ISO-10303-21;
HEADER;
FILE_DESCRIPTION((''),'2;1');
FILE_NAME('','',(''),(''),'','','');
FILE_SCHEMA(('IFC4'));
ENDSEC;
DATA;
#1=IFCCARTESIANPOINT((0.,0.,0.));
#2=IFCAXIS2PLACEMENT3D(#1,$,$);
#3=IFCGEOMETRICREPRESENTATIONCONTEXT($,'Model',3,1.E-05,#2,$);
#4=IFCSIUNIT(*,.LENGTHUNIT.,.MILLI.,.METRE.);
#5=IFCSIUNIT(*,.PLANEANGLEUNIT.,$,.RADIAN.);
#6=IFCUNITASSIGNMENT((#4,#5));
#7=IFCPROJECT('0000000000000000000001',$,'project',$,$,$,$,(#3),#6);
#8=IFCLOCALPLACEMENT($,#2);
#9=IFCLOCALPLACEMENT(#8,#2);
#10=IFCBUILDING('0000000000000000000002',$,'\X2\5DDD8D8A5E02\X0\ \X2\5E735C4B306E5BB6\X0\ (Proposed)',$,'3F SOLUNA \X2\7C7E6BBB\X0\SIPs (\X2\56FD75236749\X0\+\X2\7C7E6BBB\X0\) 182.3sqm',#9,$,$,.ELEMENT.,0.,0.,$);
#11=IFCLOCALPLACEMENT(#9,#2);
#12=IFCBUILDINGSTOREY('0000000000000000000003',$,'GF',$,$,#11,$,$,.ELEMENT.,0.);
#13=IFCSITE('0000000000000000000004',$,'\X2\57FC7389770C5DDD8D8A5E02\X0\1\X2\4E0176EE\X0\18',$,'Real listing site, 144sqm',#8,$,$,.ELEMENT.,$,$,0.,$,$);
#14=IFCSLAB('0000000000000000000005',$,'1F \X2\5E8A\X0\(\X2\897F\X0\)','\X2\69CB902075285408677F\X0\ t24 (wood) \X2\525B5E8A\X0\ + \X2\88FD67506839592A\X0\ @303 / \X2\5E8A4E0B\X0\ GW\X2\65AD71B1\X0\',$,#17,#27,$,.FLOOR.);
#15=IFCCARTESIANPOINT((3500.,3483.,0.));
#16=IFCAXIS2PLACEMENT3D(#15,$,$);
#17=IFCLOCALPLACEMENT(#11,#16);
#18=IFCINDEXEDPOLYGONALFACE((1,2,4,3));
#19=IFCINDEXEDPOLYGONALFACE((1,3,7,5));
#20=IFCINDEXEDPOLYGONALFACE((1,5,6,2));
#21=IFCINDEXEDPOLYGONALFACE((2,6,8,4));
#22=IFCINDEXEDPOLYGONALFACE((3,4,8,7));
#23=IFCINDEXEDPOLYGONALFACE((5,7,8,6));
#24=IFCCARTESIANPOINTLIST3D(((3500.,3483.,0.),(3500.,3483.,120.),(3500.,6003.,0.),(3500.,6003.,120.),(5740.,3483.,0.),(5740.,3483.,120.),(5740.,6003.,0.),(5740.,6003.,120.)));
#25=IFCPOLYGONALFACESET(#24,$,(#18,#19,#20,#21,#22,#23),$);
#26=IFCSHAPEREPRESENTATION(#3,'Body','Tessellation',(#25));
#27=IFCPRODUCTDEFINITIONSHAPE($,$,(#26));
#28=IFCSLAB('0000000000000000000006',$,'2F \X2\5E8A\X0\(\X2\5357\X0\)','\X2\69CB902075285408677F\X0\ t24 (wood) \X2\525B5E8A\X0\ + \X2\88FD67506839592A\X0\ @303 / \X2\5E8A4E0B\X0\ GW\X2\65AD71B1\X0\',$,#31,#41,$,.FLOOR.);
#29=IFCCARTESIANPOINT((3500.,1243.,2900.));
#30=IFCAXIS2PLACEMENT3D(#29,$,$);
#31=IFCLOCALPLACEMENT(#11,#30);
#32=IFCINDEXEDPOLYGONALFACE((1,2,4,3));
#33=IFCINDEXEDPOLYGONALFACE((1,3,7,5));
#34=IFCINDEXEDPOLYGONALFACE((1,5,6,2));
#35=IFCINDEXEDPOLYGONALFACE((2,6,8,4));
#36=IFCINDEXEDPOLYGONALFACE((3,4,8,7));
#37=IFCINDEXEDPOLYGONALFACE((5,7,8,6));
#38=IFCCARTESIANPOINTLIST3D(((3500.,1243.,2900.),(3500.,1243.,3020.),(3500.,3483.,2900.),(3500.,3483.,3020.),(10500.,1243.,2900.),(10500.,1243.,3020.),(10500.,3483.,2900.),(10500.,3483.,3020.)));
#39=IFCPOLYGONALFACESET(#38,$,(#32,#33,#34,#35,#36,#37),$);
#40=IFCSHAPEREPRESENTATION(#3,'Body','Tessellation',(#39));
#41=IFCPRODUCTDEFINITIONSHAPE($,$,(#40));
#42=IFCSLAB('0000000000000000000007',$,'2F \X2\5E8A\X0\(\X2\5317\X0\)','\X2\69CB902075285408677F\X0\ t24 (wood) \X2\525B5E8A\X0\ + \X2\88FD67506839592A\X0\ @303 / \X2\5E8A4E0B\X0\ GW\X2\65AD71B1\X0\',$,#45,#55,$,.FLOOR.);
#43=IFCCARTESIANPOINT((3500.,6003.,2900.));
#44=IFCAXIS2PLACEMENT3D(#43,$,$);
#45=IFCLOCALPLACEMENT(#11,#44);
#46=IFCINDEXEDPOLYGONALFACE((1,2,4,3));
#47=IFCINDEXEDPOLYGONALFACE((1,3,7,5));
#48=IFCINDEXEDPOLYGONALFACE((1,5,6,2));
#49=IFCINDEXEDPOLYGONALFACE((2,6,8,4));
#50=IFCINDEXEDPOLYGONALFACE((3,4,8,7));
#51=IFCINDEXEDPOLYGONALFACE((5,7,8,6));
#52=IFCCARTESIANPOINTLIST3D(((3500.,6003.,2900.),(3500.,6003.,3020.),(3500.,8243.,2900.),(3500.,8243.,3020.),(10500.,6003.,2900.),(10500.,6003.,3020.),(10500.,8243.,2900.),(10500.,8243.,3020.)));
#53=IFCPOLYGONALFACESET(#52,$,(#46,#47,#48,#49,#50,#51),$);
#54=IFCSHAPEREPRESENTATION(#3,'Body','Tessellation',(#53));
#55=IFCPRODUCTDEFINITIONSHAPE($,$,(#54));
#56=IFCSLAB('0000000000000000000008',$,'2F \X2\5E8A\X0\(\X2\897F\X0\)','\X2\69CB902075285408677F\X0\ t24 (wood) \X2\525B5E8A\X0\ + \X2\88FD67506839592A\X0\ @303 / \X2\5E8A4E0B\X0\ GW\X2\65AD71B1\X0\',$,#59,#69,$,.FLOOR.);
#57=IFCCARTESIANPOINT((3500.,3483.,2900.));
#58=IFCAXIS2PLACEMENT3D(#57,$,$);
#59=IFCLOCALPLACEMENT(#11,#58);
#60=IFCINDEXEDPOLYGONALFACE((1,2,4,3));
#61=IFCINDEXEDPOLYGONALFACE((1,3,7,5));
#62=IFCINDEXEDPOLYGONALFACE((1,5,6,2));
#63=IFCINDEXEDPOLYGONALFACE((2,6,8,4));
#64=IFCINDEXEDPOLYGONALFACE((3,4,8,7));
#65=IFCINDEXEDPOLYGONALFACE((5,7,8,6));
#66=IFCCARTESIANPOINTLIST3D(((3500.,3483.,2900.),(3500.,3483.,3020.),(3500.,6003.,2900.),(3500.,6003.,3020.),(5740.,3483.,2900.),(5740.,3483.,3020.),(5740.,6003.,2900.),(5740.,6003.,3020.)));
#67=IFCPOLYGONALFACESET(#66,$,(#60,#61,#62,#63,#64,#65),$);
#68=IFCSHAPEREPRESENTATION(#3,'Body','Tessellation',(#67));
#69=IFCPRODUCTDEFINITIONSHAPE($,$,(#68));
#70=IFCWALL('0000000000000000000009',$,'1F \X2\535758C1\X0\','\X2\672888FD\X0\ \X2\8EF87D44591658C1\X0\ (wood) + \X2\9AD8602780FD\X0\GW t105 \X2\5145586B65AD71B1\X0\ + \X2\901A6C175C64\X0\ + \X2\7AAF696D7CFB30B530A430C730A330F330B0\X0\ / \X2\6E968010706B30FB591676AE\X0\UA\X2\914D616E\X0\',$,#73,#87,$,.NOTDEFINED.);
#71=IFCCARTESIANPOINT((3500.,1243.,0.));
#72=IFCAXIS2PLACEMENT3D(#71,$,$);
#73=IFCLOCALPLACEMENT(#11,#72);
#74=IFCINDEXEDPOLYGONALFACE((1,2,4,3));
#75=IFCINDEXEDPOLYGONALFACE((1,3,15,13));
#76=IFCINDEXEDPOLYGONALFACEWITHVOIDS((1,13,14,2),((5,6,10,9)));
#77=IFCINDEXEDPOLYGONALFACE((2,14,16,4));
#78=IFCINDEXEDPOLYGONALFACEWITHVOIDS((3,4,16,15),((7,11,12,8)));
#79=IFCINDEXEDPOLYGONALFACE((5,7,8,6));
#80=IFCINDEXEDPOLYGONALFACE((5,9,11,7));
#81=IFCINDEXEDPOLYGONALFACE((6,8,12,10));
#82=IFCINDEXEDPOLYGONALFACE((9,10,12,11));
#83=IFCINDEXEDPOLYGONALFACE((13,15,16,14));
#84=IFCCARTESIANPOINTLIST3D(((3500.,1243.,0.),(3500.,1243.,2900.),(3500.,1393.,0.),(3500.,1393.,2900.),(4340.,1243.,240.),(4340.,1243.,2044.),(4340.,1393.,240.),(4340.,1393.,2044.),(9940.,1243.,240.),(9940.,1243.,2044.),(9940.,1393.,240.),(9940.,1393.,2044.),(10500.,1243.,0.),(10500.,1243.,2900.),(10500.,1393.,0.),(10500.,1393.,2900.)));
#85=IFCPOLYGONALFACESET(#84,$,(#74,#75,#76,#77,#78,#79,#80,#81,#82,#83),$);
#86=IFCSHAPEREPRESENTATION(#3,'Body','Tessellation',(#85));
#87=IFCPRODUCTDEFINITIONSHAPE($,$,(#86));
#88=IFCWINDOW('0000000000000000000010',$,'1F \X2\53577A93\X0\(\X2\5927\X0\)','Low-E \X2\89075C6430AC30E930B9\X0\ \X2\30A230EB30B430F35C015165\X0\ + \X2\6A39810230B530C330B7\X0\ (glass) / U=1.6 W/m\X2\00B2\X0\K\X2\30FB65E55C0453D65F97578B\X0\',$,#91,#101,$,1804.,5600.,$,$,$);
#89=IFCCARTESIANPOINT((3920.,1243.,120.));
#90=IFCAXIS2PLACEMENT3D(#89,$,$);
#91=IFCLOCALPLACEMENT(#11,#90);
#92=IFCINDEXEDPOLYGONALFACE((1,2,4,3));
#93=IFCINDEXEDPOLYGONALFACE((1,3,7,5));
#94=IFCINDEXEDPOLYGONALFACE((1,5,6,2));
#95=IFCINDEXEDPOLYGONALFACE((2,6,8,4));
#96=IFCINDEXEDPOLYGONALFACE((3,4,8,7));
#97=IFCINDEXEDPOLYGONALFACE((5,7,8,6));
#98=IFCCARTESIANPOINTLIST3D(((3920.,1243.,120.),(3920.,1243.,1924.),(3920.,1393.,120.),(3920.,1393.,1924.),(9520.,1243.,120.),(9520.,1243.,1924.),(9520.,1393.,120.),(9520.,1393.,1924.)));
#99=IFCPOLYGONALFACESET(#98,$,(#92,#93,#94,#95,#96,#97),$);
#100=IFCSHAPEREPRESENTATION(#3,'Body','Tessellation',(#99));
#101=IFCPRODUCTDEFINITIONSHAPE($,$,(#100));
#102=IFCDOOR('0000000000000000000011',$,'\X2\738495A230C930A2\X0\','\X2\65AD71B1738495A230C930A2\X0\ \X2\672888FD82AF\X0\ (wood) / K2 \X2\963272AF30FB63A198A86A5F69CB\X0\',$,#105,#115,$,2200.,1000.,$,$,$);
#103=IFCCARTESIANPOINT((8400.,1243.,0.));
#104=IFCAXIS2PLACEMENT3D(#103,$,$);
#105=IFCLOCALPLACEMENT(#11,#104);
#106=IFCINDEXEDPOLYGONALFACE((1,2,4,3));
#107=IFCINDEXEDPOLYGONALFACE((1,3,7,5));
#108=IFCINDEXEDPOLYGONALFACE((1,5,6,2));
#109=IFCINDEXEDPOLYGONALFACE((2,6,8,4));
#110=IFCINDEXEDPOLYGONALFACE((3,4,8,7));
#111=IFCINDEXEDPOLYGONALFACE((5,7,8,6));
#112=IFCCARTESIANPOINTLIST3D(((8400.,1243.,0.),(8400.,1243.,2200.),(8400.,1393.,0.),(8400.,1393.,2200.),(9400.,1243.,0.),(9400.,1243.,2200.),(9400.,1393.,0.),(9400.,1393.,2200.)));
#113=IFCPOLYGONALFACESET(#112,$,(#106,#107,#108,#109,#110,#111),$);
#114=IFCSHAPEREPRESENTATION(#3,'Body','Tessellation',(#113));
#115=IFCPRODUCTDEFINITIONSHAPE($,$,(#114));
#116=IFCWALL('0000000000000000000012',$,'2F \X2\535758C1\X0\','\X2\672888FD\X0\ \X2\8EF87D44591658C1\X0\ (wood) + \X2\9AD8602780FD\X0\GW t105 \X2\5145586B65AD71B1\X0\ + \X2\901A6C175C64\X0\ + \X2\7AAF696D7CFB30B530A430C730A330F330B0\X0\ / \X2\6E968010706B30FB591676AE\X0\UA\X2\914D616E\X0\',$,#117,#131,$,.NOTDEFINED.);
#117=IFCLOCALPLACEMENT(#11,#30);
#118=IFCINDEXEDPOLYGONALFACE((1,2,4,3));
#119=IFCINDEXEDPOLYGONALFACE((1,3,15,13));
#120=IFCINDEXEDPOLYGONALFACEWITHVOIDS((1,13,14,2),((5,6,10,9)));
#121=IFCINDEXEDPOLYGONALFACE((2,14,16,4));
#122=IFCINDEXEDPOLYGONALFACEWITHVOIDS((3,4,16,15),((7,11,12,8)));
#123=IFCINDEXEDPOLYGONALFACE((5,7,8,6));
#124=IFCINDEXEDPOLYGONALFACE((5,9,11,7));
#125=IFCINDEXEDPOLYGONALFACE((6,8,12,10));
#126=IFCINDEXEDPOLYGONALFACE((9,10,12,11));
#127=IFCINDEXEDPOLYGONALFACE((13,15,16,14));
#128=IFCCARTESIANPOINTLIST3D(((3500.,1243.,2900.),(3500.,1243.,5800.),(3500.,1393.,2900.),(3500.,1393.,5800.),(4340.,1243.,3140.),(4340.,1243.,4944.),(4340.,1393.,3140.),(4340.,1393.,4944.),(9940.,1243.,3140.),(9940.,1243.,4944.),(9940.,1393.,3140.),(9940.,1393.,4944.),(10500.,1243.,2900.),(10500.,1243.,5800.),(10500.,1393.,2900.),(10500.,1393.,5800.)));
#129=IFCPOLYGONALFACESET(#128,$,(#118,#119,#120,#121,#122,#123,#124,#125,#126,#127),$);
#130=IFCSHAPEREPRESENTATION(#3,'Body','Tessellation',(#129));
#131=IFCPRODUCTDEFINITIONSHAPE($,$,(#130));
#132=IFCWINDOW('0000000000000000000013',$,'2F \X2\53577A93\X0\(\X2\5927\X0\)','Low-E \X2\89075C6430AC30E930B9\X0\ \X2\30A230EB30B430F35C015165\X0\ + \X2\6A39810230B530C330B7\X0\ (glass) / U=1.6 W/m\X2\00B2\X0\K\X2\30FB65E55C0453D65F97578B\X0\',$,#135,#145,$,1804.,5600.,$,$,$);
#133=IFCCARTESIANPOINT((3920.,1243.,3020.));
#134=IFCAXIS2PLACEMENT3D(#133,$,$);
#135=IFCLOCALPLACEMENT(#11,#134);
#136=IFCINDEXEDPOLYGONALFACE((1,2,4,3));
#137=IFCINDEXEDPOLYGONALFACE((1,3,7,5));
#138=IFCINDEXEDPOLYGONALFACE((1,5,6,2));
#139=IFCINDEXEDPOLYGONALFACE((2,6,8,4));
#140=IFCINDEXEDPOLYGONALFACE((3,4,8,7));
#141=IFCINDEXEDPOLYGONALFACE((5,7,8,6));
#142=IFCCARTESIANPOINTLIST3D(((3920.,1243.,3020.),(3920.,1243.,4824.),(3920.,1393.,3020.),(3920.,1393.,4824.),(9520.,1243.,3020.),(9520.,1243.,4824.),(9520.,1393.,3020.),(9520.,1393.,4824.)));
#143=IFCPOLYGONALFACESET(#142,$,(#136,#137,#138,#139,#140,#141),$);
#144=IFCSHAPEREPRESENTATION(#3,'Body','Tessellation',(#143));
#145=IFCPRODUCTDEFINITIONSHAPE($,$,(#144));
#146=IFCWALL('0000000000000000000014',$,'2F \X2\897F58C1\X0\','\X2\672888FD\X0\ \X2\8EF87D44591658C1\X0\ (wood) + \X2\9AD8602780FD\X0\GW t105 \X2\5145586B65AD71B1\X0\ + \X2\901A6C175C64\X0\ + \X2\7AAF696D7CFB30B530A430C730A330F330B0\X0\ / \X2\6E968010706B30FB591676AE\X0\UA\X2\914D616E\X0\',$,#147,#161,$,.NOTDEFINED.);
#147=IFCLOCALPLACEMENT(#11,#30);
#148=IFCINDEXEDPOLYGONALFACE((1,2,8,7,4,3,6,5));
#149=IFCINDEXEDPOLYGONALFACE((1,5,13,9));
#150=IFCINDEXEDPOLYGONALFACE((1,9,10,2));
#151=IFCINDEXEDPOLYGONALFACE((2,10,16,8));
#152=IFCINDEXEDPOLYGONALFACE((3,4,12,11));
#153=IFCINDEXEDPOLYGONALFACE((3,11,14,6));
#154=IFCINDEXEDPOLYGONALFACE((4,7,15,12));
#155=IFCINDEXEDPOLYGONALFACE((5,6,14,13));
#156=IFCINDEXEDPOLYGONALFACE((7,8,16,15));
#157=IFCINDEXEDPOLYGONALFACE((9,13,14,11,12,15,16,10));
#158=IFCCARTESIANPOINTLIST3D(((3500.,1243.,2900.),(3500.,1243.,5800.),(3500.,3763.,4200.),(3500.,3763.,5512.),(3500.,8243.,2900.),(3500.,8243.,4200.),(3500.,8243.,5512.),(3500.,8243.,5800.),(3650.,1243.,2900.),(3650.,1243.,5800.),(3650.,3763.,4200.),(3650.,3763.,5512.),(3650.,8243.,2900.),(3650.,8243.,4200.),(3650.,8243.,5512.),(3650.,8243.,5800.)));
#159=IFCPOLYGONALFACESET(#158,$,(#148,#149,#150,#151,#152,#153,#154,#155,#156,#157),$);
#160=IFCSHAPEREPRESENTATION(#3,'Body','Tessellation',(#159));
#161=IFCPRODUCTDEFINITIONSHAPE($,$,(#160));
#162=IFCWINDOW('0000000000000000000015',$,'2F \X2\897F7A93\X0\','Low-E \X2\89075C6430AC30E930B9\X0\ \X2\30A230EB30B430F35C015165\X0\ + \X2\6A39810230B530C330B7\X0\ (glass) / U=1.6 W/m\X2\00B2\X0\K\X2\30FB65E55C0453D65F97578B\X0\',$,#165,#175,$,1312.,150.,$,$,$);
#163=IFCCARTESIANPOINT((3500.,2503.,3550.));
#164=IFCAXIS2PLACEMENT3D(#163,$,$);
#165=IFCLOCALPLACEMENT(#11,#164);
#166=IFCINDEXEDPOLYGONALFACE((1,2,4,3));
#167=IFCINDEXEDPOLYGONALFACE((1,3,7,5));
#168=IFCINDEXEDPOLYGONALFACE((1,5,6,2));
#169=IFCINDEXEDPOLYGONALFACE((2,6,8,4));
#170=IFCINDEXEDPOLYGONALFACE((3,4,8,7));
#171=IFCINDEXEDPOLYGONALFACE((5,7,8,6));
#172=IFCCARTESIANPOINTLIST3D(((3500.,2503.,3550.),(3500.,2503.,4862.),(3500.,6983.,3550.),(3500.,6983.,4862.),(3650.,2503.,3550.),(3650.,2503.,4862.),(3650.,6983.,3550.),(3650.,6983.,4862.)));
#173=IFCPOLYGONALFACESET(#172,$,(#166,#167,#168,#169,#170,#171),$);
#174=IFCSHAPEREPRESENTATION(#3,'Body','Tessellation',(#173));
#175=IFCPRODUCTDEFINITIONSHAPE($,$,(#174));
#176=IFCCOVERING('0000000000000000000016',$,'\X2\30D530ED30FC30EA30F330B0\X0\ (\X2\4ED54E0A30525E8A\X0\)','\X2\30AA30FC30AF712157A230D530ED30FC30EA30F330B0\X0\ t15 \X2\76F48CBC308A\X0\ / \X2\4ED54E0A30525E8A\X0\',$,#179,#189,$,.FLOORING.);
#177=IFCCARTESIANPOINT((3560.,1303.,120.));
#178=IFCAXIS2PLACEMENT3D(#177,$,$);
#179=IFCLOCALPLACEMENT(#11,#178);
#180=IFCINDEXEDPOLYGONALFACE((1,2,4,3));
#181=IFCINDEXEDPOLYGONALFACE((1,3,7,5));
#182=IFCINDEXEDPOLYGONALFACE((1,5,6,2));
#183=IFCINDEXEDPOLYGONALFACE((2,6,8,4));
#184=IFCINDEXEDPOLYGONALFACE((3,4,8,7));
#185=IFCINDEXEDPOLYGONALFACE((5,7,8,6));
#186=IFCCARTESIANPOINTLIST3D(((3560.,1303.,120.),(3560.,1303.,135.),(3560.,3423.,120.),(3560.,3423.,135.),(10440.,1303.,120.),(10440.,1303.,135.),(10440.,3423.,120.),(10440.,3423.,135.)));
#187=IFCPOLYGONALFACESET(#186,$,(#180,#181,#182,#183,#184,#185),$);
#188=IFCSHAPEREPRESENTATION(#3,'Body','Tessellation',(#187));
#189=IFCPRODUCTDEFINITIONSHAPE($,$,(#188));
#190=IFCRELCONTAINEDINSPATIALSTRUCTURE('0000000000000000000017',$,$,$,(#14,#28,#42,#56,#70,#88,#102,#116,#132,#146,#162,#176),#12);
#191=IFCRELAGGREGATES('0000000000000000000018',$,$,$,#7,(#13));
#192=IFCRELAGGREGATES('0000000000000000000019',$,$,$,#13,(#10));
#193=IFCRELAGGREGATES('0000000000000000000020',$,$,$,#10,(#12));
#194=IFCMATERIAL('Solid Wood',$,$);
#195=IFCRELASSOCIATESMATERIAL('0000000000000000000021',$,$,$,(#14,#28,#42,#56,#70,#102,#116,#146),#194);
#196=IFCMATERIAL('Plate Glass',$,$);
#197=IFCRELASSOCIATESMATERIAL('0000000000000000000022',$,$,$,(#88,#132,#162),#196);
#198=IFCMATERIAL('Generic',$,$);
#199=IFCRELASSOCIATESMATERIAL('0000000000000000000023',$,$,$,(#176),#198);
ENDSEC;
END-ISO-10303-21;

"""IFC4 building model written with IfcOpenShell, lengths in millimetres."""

from ifc_helpers import new_model, si_unit, frame, frame_2d, origin, place, context, project, spatial, rectangle, extrude, material, element, fill, save


model = new_model("IFC4")

# Units and contexts
model_context = context("Model", 3, precision=1e-05, world=origin())
ifc_project = project(units=[si_unit("LENGTHUNIT", "METRE", prefix="MILLI"), si_unit("PLANEANGLEUNIT", "RADIAN")], contexts=[model_context])

# Site, building, storey
site_placement = place(None, origin())
site = spatial("IfcSite", under=ifc_project, at=site_placement, Name="埼玉県川越市1丁目18", ObjectType="Real listing site, 144sqm", CompositionType="ELEMENT", RefElevation=0.0)
building_placement = place(site_placement, origin())
building = spatial("IfcBuilding", under=site, at=building_placement, Name="川越市 平屋の家 (Proposed)", ObjectType="3F SOLUNA 籾殻SIPs (国産杉+籾殻) 182.3sqm", CompositionType="ELEMENT", ElevationOfRefHeight=0.0, ElevationOfTerrain=0.0)
storey_placement = place(building_placement, origin())
storey = spatial("IfcBuildingStorey", under=building, at=storey_placement, Name="GF", CompositionType="ELEMENT", Elevation=0.0)

# Slabs
ifc_material_1 = material(Name="Solid Wood")
slab_1_placement = place(storey_placement, frame((3500.0, 3483.0, 0.0)))
element("IfcSlab", 1, at=slab_1_placement, inside=storey, material=ifc_material_1, Name="1F 床(西)", Description="構造用合板 t24 (wood) 剛床 + 製材根太 @303 / 床下 GW断熱", PredefinedType="FLOOR", context=model_context, shape_type="SweptSolid", body=[
    extrude(rectangle(XDim=2240.0, YDim=2520.0, at=frame_2d((1120.0, 1260.0))), frame((3500.0, 3483.0, 0.0)), (0.0, 0.0, 1.0), 120.0),
])
slab_2_placement = place(storey_placement, frame((3500.0, 1243.0, 2900.0)))
element("IfcSlab", 2, at=slab_2_placement, inside=storey, material=ifc_material_1, Name="2F 床(南)", Description="構造用合板 t24 (wood) 剛床 + 製材根太 @303 / 床下 GW断熱", PredefinedType="FLOOR", context=model_context, shape_type="SweptSolid", body=[
    extrude(rectangle(XDim=7000.0, YDim=2240.0, at=frame_2d((3500.0, 1120.0))), frame((3500.0, 1243.0, 2900.0)), (0.0, 0.0, 1.0), 120.0),
])
slab_3_placement = place(storey_placement, frame((3500.0, 6003.0, 2900.0)))
element("IfcSlab", 3, at=slab_3_placement, inside=storey, material=ifc_material_1, Name="2F 床(北)", Description="構造用合板 t24 (wood) 剛床 + 製材根太 @303 / 床下 GW断熱", PredefinedType="FLOOR", context=model_context, shape_type="SweptSolid", body=[
    extrude(rectangle(XDim=7000.0, YDim=2240.0, at=frame_2d((3500.0, 1120.0))), frame((3500.0, 6003.0, 2900.0)), (0.0, 0.0, 1.0), 120.0),
])
slab_4_placement = place(storey_placement, frame((3500.0, 3483.0, 2900.0)))
element("IfcSlab", 4, at=slab_4_placement, inside=storey, material=ifc_material_1, Name="2F 床(西)", Description="構造用合板 t24 (wood) 剛床 + 製材根太 @303 / 床下 GW断熱", PredefinedType="FLOOR", context=model_context, shape_type="SweptSolid", body=[
    extrude(rectangle(XDim=2240.0, YDim=2520.0, at=frame_2d((1120.0, 1260.0))), frame((3500.0, 3483.0, 2900.0)), (0.0, 0.0, 1.0), 120.0),
])

# Wall, openings, window, door
wall_1_placement = place(storey_placement, frame((3500.0, 1243.0, 0.0)))
wall_1 = element("IfcWall", 5, at=wall_1_placement, inside=storey, material=ifc_material_1, Name="1F 南壁", Description="木製 軸組外壁 (wood) + 高性能GW t105 充填断熱 + 通気層 + 窯業系サイディング / 準耐火・外皮UA配慮", PredefinedType="NOTDEFINED", context=model_context, shape_type="SweptSolid", body=[
    extrude(rectangle(XDim=7000.0, YDim=150.0, at=frame_2d((3500.0, 75.0))), frame((3500.0, 1243.0, 0.0)), (0.0, 0.0, 1.0), 2900.0),
])
opening_1_placement = place(storey_placement, frame((3920.0, 1243.0, 120.0)))
opening_1 = element("IfcOpeningElement", 6, at=opening_1_placement, cuts=wall_1, PredefinedType="NOTDEFINED", context=model_context, shape_type="SweptSolid", body=[
    extrude(rectangle(XDim=5600.0, YDim=150.0, at=frame_2d((2800.0, 75.0))), frame((3920.0, 1243.0, 120.0)), (0.0, 0.0, 1.0), 1804.0),
])
opening_2_placement = place(storey_placement, frame((8400.0, 1243.0, 0.0)))
opening_2 = element("IfcOpeningElement", 7, at=opening_2_placement, cuts=wall_1, PredefinedType="NOTDEFINED", context=model_context, shape_type="SweptSolid", body=[
    extrude(rectangle(XDim=1000.0, YDim=150.0, at=frame_2d((500.0, 75.0))), frame((8400.0, 1243.0, 0.0)), (0.0, 0.0, 1.0), 2200.0),
])
ifc_material_2 = material(Name="Plate Glass")
window_1_placement = place(storey_placement, frame((3920.0, 1243.0, 120.0)))
window_1 = element("IfcWindow", 8, at=window_1_placement, inside=storey, material=ifc_material_2, Name="1F 南窓(大)", Description="Low-E 複層ガラス アルゴン封入 + 樹脂サッシ (glass) / U=1.6 W/m²K・日射取得型", OverallHeight=1804.0, OverallWidth=5600.0, context=model_context, shape_type="SweptSolid", body=[
    extrude(rectangle(XDim=5600.0, YDim=150.0, at=frame_2d((2800.0, 75.0))), frame((3920.0, 1243.0, 120.0)), (0.0, 0.0, 1.0), 1804.0),
])
fill(opening_1, window_1)
door_placement = place(storey_placement, frame((8400.0, 1243.0, 0.0)))
door = element("IfcDoor", 9, at=door_placement, inside=storey, material=ifc_material_1, Name="玄関ドア", Description="断熱玄関ドア 木製芯 (wood) / K2 防犯・採風機構", OverallHeight=2200.0, OverallWidth=1000.0, context=model_context, shape_type="SweptSolid", body=[
    extrude(rectangle(XDim=1000.0, YDim=150.0, at=frame_2d((500.0, 75.0))), frame((8400.0, 1243.0, 0.0)), (0.0, 0.0, 1.0), 2200.0),
])
fill(opening_2, door)

# Wall, opening, window
wall_2_placement = place(storey_placement, frame((3500.0, 1243.0, 2900.0)))
wall_2 = element("IfcWall", 10, at=wall_2_placement, inside=storey, material=ifc_material_1, Name="2F 南壁", Description="木製 軸組外壁 (wood) + 高性能GW t105 充填断熱 + 通気層 + 窯業系サイディング / 準耐火・外皮UA配慮", PredefinedType="NOTDEFINED", context=model_context, shape_type="SweptSolid", body=[
    extrude(rectangle(XDim=7000.0, YDim=150.0, at=frame_2d((3500.0, 75.0))), frame((3500.0, 1243.0, 2900.0)), (0.0, 0.0, 1.0), 2900.0),
])
opening_3_placement = place(storey_placement, frame((3920.0, 1243.0, 3020.0)))
opening_3 = element("IfcOpeningElement", 11, at=opening_3_placement, cuts=wall_2, PredefinedType="NOTDEFINED", context=model_context, shape_type="SweptSolid", body=[
    extrude(rectangle(XDim=5600.0, YDim=150.0, at=frame_2d((2800.0, 75.0))), frame((3920.0, 1243.0, 3020.0)), (0.0, 0.0, 1.0), 1804.0),
])
window_2_placement = place(storey_placement, frame((3920.0, 1243.0, 3020.0)))
window_2 = element("IfcWindow", 12, at=window_2_placement, inside=storey, material=ifc_material_2, Name="2F 南窓(大)", Description="Low-E 複層ガラス アルゴン封入 + 樹脂サッシ (glass) / U=1.6 W/m²K・日射取得型", OverallHeight=1804.0, OverallWidth=5600.0, context=model_context, shape_type="SweptSolid", body=[
    extrude(rectangle(XDim=5600.0, YDim=150.0, at=frame_2d((2800.0, 75.0))), frame((3920.0, 1243.0, 3020.0)), (0.0, 0.0, 1.0), 1804.0),
])
fill(opening_3, window_2)

# Wall, opening, window
wall_3_placement = place(storey_placement, frame((3500.0, 1243.0, 2900.0)))
wall_3 = element("IfcWall", 13, at=wall_3_placement, inside=storey, material=ifc_material_1, Name="2F 西壁", Description="木製 軸組外壁 (wood) + 高性能GW t105 充填断熱 + 通気層 + 窯業系サイディング / 準耐火・外皮UA配慮", PredefinedType="NOTDEFINED", context=model_context, shape_type="SweptSolid", body=[
    extrude(rectangle(XDim=150.0, YDim=7000.0, at=frame_2d((75.0, 3500.0))), frame((3500.0, 1243.0, 2900.0)), (0.0, 0.0, 1.0), 2900.0),
])
opening_4_placement = place(storey_placement, frame((3500.0, 2503.0, 3550.0)))
opening_4 = element("IfcOpeningElement", 14, at=opening_4_placement, cuts=wall_3, PredefinedType="NOTDEFINED", context=model_context, shape_type="SweptSolid", body=[
    extrude(rectangle(XDim=150.0, YDim=4480.0, at=frame_2d((75.0, 2240.0))), frame((3500.0, 2503.0, 3550.0)), (0.0, 0.0, 1.0), 1312.0),
])
window_3_placement = place(storey_placement, frame((3500.0, 2503.0, 3550.0)))
window_3 = element("IfcWindow", 15, at=window_3_placement, inside=storey, material=ifc_material_2, Name="2F 西窓", Description="Low-E 複層ガラス アルゴン封入 + 樹脂サッシ (glass) / U=1.6 W/m²K・日射取得型", OverallHeight=1312.0, OverallWidth=150.0, context=model_context, shape_type="SweptSolid", body=[
    extrude(rectangle(XDim=150.0, YDim=4480.0, at=frame_2d((75.0, 2240.0))), frame((3500.0, 2503.0, 3550.0)), (0.0, 0.0, 1.0), 1312.0),
])
fill(opening_4, window_3)

# Covering
ifc_material_3 = material(Name="Generic")
covering_1_placement = place(storey_placement, frame((3560.0, 1303.0, 120.0)))
element("IfcCovering", 16, at=covering_1_placement, inside=storey, material=ifc_material_3, Name="フローリング (仕上げ床)", Description="オーク無垢フローリング t15 直貼り / 仕上げ床", PredefinedType="FLOORING", context=model_context, shape_type="SweptSolid", body=[
    extrude(rectangle(XDim=6880.0, YDim=2120.0, at=frame_2d((3440.0, 1060.0))), frame((3560.0, 1303.0, 120.0)), (0.0, 0.0, 1.0), 15.0),
])

save(model, "model.ifc")
